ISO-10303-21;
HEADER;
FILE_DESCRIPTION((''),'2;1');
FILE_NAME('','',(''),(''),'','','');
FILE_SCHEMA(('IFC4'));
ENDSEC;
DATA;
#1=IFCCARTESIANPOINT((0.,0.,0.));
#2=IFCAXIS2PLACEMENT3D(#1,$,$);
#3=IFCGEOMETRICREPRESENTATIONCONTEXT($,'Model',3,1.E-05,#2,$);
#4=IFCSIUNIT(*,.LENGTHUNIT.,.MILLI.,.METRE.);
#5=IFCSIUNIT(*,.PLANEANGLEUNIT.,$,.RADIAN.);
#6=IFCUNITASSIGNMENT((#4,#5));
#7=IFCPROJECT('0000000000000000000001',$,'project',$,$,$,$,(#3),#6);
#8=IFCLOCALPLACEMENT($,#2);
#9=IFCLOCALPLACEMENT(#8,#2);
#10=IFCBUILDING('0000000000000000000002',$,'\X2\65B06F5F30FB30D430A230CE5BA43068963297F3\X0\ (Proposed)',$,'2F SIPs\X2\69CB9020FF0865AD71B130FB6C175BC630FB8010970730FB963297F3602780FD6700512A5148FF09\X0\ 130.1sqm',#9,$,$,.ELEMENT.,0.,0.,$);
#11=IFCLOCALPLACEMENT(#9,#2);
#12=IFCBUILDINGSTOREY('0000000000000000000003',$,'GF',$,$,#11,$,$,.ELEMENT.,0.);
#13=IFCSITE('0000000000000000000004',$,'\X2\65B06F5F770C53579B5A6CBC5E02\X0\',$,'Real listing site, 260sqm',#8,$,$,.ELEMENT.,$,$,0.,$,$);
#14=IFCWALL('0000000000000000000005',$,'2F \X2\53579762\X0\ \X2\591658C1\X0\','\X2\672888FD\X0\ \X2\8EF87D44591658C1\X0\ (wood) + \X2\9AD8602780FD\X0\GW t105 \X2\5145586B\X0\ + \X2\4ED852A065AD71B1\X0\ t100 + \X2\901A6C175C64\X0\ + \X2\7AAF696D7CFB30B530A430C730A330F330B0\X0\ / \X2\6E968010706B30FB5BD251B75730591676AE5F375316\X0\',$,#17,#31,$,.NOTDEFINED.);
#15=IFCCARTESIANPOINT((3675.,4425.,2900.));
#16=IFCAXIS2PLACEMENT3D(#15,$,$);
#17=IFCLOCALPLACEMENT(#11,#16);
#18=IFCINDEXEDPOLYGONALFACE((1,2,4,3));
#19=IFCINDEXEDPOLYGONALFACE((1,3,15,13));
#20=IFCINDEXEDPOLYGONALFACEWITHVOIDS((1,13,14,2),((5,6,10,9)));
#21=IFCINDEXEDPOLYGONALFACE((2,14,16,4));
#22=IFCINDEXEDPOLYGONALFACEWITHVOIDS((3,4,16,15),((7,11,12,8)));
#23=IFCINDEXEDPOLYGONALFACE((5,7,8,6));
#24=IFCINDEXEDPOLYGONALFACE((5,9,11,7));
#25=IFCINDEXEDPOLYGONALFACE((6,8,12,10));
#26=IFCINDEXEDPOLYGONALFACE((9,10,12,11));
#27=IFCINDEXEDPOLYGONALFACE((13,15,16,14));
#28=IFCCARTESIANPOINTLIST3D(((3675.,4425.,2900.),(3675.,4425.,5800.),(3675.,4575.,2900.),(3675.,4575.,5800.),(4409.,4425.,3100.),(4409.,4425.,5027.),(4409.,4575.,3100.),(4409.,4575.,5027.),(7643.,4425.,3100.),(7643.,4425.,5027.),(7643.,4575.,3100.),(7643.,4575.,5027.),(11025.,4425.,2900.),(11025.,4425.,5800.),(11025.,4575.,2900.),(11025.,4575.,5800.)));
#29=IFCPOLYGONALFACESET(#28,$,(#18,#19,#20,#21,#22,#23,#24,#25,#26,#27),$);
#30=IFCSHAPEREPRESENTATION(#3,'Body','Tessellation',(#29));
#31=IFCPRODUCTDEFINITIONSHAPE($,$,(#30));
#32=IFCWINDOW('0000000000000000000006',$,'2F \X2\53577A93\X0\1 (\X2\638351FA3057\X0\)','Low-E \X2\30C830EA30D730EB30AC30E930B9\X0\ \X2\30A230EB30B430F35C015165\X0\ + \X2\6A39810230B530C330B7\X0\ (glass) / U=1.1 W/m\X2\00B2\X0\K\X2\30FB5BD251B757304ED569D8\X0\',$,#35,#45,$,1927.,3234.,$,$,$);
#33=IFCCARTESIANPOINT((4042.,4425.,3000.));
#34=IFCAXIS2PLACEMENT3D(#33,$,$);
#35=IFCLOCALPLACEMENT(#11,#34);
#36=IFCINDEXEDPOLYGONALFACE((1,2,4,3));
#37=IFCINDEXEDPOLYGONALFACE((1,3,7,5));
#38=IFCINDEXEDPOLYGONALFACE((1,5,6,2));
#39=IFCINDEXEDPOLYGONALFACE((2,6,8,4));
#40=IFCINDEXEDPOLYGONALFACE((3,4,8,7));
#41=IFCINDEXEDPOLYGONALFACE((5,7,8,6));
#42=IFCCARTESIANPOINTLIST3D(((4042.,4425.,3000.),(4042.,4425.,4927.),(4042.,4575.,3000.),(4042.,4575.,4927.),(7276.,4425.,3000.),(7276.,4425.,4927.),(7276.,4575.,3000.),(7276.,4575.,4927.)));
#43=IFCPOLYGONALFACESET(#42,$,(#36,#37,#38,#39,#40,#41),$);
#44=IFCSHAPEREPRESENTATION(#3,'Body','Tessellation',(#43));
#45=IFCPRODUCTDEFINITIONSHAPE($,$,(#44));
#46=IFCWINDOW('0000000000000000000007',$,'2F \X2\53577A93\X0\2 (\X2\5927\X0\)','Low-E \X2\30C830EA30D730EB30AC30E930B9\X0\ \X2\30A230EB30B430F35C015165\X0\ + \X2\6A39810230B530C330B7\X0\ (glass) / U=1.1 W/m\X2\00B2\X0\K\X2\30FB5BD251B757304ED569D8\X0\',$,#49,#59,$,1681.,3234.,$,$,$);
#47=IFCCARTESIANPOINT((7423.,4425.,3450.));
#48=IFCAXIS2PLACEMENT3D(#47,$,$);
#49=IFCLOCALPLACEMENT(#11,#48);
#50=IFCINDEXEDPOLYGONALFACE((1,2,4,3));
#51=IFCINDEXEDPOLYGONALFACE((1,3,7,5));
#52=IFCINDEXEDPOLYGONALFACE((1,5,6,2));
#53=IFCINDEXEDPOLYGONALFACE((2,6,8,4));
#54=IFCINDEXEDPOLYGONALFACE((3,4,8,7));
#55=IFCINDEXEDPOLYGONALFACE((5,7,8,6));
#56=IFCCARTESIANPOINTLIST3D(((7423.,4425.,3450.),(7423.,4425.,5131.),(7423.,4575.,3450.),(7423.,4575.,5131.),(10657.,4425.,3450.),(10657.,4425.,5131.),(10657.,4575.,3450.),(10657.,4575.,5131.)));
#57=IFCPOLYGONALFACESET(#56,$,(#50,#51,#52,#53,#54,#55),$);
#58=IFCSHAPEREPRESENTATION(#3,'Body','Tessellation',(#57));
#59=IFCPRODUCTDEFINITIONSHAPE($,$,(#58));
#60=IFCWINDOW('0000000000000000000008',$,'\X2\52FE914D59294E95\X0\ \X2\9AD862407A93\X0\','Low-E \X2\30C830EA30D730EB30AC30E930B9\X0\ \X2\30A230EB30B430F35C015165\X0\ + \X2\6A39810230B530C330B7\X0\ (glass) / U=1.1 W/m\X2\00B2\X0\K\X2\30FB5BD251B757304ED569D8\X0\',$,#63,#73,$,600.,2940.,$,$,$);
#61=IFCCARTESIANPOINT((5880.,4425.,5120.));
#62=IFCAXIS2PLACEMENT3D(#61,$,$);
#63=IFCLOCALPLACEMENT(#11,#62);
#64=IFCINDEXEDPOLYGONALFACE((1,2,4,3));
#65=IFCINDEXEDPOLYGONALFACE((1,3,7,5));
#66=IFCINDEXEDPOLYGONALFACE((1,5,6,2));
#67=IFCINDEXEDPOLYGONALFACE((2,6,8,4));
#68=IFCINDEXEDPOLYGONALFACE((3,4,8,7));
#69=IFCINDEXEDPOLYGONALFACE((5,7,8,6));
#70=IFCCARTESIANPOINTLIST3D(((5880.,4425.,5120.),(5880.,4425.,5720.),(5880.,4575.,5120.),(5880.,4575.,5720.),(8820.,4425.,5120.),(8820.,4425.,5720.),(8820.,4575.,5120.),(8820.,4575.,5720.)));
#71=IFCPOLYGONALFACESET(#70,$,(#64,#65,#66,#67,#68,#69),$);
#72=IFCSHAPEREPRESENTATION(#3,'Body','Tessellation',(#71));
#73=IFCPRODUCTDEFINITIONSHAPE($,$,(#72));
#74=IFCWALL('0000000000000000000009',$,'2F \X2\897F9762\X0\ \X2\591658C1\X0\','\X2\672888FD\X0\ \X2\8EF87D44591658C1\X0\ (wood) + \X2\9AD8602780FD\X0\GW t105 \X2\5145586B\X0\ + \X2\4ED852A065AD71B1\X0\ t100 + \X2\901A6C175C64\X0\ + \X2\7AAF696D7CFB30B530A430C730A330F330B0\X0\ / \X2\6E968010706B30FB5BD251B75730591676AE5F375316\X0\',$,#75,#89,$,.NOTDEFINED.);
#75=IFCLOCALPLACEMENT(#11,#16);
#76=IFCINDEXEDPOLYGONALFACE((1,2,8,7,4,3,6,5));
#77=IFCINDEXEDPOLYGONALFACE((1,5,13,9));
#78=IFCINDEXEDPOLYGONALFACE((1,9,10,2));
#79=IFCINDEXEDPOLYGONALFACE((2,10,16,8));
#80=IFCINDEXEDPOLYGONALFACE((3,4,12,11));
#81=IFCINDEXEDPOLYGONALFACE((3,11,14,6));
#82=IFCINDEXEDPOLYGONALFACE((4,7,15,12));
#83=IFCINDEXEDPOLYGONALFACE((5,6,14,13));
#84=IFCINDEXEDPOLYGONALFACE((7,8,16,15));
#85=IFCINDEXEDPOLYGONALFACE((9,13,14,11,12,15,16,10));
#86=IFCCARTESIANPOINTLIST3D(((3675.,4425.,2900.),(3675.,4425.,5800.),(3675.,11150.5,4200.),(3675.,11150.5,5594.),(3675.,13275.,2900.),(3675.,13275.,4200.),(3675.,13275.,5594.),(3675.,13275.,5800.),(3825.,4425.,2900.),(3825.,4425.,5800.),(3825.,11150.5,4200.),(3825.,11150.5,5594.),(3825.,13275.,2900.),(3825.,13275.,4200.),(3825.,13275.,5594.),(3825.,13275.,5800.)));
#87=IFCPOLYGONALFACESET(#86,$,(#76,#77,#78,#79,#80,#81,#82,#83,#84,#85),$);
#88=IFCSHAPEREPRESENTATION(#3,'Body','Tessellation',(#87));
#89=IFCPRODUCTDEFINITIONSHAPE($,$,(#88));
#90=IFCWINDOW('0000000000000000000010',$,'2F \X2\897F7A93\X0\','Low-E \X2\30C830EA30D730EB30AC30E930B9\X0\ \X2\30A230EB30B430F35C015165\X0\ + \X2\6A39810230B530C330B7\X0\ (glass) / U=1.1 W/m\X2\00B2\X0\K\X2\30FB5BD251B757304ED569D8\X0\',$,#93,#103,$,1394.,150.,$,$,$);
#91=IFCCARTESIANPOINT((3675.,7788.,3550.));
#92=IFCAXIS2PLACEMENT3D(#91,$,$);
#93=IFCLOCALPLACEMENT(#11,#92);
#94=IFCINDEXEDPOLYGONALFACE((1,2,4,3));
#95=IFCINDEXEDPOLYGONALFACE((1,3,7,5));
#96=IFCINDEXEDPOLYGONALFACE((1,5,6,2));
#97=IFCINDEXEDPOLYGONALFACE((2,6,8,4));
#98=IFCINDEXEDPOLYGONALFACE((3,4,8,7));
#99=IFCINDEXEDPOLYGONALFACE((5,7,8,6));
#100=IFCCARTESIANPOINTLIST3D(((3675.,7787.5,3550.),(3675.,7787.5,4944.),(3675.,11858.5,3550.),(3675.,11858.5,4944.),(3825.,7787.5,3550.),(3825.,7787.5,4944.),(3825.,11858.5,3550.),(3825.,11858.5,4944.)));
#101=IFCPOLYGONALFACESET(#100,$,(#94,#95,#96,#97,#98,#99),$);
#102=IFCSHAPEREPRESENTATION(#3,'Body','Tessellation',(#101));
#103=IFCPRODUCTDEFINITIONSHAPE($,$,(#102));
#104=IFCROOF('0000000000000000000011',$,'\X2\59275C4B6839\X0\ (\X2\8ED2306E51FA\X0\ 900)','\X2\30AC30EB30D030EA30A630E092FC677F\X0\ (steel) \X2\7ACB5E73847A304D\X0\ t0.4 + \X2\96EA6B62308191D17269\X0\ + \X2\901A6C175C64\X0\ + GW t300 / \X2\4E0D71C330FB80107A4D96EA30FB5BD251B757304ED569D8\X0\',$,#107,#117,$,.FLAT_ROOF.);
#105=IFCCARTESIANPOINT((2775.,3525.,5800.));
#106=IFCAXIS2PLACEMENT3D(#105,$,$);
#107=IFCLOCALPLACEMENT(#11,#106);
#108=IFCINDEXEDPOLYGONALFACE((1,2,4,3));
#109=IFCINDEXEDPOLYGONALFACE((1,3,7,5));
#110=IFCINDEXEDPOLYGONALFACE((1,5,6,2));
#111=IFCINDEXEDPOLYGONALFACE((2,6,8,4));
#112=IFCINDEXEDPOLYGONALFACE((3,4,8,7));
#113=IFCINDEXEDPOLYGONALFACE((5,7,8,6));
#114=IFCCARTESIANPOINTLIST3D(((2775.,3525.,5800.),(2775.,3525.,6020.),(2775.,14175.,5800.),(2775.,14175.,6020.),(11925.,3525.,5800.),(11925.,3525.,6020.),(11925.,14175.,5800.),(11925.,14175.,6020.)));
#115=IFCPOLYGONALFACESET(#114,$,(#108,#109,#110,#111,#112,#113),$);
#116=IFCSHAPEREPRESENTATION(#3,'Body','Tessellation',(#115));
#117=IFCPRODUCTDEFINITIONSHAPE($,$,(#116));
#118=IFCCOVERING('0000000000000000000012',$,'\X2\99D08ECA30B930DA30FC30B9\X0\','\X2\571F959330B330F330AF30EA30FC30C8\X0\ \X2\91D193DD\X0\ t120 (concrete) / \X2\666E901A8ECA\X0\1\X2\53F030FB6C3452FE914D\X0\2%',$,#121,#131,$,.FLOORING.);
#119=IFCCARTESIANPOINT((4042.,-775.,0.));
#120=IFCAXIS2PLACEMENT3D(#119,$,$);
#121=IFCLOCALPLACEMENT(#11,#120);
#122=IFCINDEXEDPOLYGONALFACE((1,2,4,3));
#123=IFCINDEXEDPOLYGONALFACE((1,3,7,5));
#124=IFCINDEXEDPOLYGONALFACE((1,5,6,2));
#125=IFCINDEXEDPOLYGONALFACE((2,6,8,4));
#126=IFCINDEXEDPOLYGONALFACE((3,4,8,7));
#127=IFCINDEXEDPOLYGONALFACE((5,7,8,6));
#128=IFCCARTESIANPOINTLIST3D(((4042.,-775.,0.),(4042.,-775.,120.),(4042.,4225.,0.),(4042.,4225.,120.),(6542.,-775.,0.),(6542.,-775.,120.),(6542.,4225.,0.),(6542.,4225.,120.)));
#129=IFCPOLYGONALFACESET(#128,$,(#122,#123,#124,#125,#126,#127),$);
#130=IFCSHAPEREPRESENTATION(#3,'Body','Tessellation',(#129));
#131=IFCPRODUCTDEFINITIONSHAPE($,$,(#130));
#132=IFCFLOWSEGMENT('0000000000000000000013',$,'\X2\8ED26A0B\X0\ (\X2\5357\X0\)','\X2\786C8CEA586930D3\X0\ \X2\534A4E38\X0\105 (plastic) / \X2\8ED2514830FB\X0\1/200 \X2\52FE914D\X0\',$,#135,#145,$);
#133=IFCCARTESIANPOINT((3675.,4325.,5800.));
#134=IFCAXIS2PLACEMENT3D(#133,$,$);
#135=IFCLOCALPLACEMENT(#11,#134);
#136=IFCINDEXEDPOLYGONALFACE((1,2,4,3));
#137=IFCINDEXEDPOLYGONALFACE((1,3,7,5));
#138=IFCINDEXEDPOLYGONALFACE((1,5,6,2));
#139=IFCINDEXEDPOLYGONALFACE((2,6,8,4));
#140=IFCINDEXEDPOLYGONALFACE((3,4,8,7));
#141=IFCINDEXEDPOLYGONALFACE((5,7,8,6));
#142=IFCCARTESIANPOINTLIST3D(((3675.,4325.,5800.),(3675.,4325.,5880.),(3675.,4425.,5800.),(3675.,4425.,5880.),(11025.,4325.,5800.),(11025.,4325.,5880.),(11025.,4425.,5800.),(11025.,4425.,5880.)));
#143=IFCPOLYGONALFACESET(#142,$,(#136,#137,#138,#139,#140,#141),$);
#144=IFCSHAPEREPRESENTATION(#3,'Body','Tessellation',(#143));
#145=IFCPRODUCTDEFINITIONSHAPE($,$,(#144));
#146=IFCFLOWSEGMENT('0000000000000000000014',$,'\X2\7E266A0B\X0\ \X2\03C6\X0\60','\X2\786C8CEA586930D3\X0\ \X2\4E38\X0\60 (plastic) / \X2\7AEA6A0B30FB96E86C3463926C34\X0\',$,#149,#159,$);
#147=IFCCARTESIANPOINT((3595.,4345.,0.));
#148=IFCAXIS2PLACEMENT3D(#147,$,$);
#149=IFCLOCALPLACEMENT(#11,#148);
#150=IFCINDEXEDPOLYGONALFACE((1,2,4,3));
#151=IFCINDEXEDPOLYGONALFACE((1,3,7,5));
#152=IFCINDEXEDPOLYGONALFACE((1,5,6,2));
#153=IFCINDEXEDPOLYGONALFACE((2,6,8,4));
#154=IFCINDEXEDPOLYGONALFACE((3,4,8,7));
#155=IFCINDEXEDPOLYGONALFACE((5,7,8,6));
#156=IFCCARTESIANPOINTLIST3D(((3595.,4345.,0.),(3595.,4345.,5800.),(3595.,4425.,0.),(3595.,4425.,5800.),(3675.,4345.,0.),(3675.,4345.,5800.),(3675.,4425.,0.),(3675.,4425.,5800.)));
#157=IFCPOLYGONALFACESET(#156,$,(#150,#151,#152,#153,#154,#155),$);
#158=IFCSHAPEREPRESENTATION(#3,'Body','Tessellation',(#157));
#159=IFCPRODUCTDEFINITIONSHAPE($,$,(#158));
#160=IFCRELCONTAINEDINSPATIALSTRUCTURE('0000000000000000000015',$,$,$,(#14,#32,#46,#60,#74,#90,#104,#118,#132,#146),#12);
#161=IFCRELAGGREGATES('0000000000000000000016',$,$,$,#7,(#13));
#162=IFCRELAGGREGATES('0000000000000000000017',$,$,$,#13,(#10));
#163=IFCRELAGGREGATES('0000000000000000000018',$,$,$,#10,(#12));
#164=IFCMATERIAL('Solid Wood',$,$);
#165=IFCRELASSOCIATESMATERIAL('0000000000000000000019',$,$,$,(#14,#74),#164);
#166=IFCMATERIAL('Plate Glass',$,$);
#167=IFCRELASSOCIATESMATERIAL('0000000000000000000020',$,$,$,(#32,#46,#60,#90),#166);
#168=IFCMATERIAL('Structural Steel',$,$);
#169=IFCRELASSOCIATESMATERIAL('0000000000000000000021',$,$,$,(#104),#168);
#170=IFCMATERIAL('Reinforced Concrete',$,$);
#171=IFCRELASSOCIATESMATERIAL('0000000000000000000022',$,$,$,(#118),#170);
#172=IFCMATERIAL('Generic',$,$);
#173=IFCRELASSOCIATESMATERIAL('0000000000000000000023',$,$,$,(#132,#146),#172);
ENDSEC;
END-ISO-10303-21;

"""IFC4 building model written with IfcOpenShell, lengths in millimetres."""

from ifc_helpers import new_model, si_unit, frame, frame_2d, origin, place, context, project, spatial, rectangle, extrude, material, element, fill, save


model = new_model("IFC4")

# Units and contexts
model_context = context("Model", 3, precision=1e-05, world=origin())
ifc_project = project(units=[si_unit("LENGTHUNIT", "METRE", prefix="MILLI"), si_unit("PLANEANGLEUNIT", "RADIAN")], contexts=[model_context])

# Site, building, storey
site_placement = place(None, origin())
site = spatial("IfcSite", under=ifc_project, at=site_placement, Name="新潟県南魚沼市", ObjectType="Real listing site, 260sqm", CompositionType="ELEMENT", RefElevation=0.0)
building_placement = place(site_placement, origin())
building = spatial("IfcBuilding", under=site, at=building_placement, Name="新潟・ピアノ室と防音 (Proposed)", ObjectType="2F SIPs構造（断熱・気密・耐震・防音性能最優先） 130.1sqm", CompositionType="ELEMENT", ElevationOfRefHeight=0.0, ElevationOfTerrain=0.0)
storey_placement = place(building_placement, origin())
storey = spatial("IfcBuildingStorey", under=building, at=storey_placement, Name="GF", CompositionType="ELEMENT", Elevation=0.0)

# Shared definitions
ifc_material_1 = material(Name="Solid Wood")

# Shared definitions
ifc_material_2 = material(Name="Reinforced Concrete")

# Shared definitions
ifc_material_3 = material(Name="Plate Glass")

# Wall, openings, windows
wall_1_placement = place(storey_placement, frame((3675.0, 4425.0, 2900.0)))
wall_1 = element("IfcWall", 1, at=wall_1_placement, inside=storey, material=ifc_material_1, Name="2F 南面 外壁", Description="木製 軸組外壁 (wood) + 高性能GW t105 充填 + 付加断熱 t100 + 通気層 + 窯業系サイディング / 準耐火・寒冷地外皮強化", PredefinedType="NOTDEFINED", context=model_context, shape_type="SweptSolid", body=[
    extrude(rectangle(XDim=7350.0, YDim=150.0, at=frame_2d((3675.0, 75.0))), frame((3675.0, 4425.0, 2900.0)), (0.0, 0.0, 1.0), 2900.0),
])
opening_1_placement = place(storey_placement, frame((4042.0, 4425.0, 3000.0)))
opening_1 = element("IfcOpeningElement", 2, at=opening_1_placement, cuts=wall_1, PredefinedType="NOTDEFINED", context=model_context, shape_type="SweptSolid", body=[
    extrude(rectangle(XDim=3234.0, YDim=150.0, at=frame_2d((1617.0, 75.0))), frame((4042.0, 4425.0, 3000.0)), (0.0, 0.0, 1.0), 1927.0),
])
opening_2_placement = place(storey_placement, frame((7423.0, 4425.0, 3450.0)))
opening_2 = element("IfcOpeningElement", 3, at=opening_2_placement, cuts=wall_1, PredefinedType="NOTDEFINED", context=model_context, shape_type="SweptSolid", body=[
    extrude(rectangle(XDim=3234.0, YDim=150.0, at=frame_2d((1617.0, 75.0))), frame((7423.0, 4425.0, 3450.0)), (0.0, 0.0, 1.0), 1681.0),
])
opening_3_placement = place(storey_placement, frame((5880.0, 4425.0, 5120.0)))
opening_3 = element("IfcOpeningElement", 4, at=opening_3_placement, cuts=wall_1, PredefinedType="NOTDEFINED", context=model_context, shape_type="SweptSolid", body=[
    extrude(rectangle(XDim=2940.0, YDim=150.0, at=frame_2d((1470.0, 75.0))), frame((5880.0, 4425.0, 5120.0)), (0.0, 0.0, 1.0), 600.0),
])
window_1_placement = place(storey_placement, frame((4042.0, 4425.0, 3000.0)))
window_1 = element("IfcWindow", 5, at=window_1_placement, inside=storey, material=ifc_material_3, Name="2F 南窓1 (掃出し)", Description="Low-E トリプルガラス アルゴン封入 + 樹脂サッシ (glass) / U=1.1 W/m²K・寒冷地仕様", OverallHeight=1927.0, OverallWidth=3234.0, context=model_context, shape_type="SweptSolid", body=[
    extrude(rectangle(XDim=3234.0, YDim=150.0, at=frame_2d((1617.0, 75.0))), frame((4042.0, 4425.0, 3000.0)), (0.0, 0.0, 1.0), 1927.0),
])
fill(opening_1, window_1)
window_2_placement = place(storey_placement, frame((7423.0, 4425.0, 3450.0)))
window_2 = element("IfcWindow", 6, at=window_2_placement, inside=storey, material=ifc_material_3, Name="2F 南窓2 (大)", Description="Low-E トリプルガラス アルゴン封入 + 樹脂サッシ (glass) / U=1.1 W/m²K・寒冷地仕様", OverallHeight=1681.0, OverallWidth=3234.0, context=model_context, shape_type="SweptSolid", body=[
    extrude(rectangle(XDim=3234.0, YDim=150.0, at=frame_2d((1617.0, 75.0))), frame((7423.0, 4425.0, 3450.0)), (0.0, 0.0, 1.0), 1681.0),
])
fill(opening_2, window_2)
window_3_placement = place(storey_placement, frame((5880.0, 4425.0, 5120.0)))
window_3 = element("IfcWindow", 7, at=window_3_placement, inside=storey, material=ifc_material_3, Name="勾配天井 高所窓", Description="Low-E トリプルガラス アルゴン封入 + 樹脂サッシ (glass) / U=1.1 W/m²K・寒冷地仕様", OverallHeight=600.0, OverallWidth=2940.0, context=model_context, shape_type="SweptSolid", body=[
    extrude(rectangle(XDim=2940.0, YDim=150.0, at=frame_2d((1470.0, 75.0))), frame((5880.0, 4425.0, 5120.0)), (0.0, 0.0, 1.0), 600.0),
])
fill(opening_3, window_3)

# Wall, opening, window
wall_2_placement = place(storey_placement, frame((3675.0, 4425.0, 2900.0)))
wall_2 = element("IfcWall", 8, at=wall_2_placement, inside=storey, material=ifc_material_1, Name="2F 西面 外壁", Description="木製 軸組外壁 (wood) + 高性能GW t105 充填 + 付加断熱 t100 + 通気層 + 窯業系サイディング / 準耐火・寒冷地外皮強化", PredefinedType="NOTDEFINED", context=model_context, shape_type="SweptSolid", body=[
    extrude(rectangle(XDim=150.0, YDim=8850.0, at=frame_2d((75.0, 4425.0))), frame((3675.0, 4425.0, 2900.0)), (0.0, 0.0, 1.0), 2900.0),
])
opening_4_placement = place(storey_placement, frame((3675.0, 7788.0, 3550.0)))
opening_4 = element("IfcOpeningElement", 9, at=opening_4_placement, cuts=wall_2, PredefinedType="NOTDEFINED", context=model_context, shape_type="SweptSolid", body=[
    extrude(rectangle(XDim=150.0, YDim=4071.0, at=frame_2d((75.0, 2035.0))), frame((3675.0, 7788.0, 3550.0)), (0.0, 0.0, 1.0), 1394.0),
])
window_4_placement = place(storey_placement, frame((3675.0, 7788.0, 3550.0)))
window_4 = element("IfcWindow", 10, at=window_4_placement, inside=storey, material=ifc_material_3, Name="2F 西窓", Description="Low-E トリプルガラス アルゴン封入 + 樹脂サッシ (glass) / U=1.1 W/m²K・寒冷地仕様", OverallHeight=1394.0, OverallWidth=150.0, context=model_context, shape_type="SweptSolid", body=[
    extrude(rectangle(XDim=150.0, YDim=4071.0, at=frame_2d((75.0, 2035.0))), frame((3675.0, 7788.0, 3550.0)), (0.0, 0.0, 1.0), 1394.0),
])
fill(opening_4, window_4)

# Roof
ifc_material_4 = material(Name="Structural Steel")
roof_placement = place(storey_placement, frame((2775.0, 3525.0, 5800.0)))
element("IfcRoof", 11, at=roof_placement, inside=storey, material=ifc_material_4, Name="大屋根 (軒の出 900)", Description="ガルバリウム鋼板 (steel) 立平葺き t0.4 + 雪止め金物 + 通気層 + GW t300 / 不燃・耐積雪・寒冷地仕様", PredefinedType="FLAT_ROOF", context=model_context, shape_type="SweptSolid", body=[
    extrude(rectangle(XDim=9150.0, YDim=10650.0, at=frame_2d((4575.0, 5325.0))), frame((2775.0, 3525.0, 5800.0)), (0.0, 0.0, 1.0), 220.0),
])

# Covering
covering_placement = place(storey_placement, frame((4042.0, -775.0, 0.0)))
element("IfcCovering", 12, at=covering_placement, inside=storey, material=ifc_material_2, Name="駐車スペース", Description="土間コンクリート 金鏝 t120 (concrete) / 普通車1台・水勾配2%", PredefinedType="FLOORING", context=model_context, shape_type="SweptSolid", body=[
    extrude(rectangle(XDim=2500.0, YDim=5000.0, at=frame_2d((1250.0, 2500.0))), frame((4042.0, -775.0, 0.0)), (0.0, 0.0, 1.0), 120.0),
])

# Flow segments
ifc_material_5 = material(Name="Generic")
flow_segment_1_placement = place(storey_placement, frame((3675.0, 4325.0, 5800.0)))
element("IfcFlowSegment", 13, at=flow_segment_1_placement, inside=storey, material=ifc_material_5, Name="軒樋 (南)", Description="硬質塩ビ 半丸105 (plastic) / 軒先・1/200 勾配", context=model_context, shape_type="SweptSolid", body=[
    extrude(rectangle(XDim=7350.0, YDim=100.0, at=frame_2d((3675.0, 50.0))), frame((3675.0, 4325.0, 5800.0)), (0.0, 0.0, 1.0), 80.0),
])
flow_segment_2_placement = place(storey_placement, frame((3595.0, 4345.0, 0.0)))
element("IfcFlowSegment", 14, at=flow_segment_2_placement, inside=storey, material=ifc_material_5, Name="縦樋 φ60", Description="硬質塩ビ 丸60 (plastic) / 竪樋・雨水排水", context=model_context, shape_type="SweptSolid", body=[
    extrude(rectangle(XDim=80.0, YDim=80.0, at=frame_2d((40.0, 40.0))), frame((3595.0, 4345.0, 0.0)), (0.0, 0.0, 1.0), 5800.0),
])

save(model, "model.ifc")
